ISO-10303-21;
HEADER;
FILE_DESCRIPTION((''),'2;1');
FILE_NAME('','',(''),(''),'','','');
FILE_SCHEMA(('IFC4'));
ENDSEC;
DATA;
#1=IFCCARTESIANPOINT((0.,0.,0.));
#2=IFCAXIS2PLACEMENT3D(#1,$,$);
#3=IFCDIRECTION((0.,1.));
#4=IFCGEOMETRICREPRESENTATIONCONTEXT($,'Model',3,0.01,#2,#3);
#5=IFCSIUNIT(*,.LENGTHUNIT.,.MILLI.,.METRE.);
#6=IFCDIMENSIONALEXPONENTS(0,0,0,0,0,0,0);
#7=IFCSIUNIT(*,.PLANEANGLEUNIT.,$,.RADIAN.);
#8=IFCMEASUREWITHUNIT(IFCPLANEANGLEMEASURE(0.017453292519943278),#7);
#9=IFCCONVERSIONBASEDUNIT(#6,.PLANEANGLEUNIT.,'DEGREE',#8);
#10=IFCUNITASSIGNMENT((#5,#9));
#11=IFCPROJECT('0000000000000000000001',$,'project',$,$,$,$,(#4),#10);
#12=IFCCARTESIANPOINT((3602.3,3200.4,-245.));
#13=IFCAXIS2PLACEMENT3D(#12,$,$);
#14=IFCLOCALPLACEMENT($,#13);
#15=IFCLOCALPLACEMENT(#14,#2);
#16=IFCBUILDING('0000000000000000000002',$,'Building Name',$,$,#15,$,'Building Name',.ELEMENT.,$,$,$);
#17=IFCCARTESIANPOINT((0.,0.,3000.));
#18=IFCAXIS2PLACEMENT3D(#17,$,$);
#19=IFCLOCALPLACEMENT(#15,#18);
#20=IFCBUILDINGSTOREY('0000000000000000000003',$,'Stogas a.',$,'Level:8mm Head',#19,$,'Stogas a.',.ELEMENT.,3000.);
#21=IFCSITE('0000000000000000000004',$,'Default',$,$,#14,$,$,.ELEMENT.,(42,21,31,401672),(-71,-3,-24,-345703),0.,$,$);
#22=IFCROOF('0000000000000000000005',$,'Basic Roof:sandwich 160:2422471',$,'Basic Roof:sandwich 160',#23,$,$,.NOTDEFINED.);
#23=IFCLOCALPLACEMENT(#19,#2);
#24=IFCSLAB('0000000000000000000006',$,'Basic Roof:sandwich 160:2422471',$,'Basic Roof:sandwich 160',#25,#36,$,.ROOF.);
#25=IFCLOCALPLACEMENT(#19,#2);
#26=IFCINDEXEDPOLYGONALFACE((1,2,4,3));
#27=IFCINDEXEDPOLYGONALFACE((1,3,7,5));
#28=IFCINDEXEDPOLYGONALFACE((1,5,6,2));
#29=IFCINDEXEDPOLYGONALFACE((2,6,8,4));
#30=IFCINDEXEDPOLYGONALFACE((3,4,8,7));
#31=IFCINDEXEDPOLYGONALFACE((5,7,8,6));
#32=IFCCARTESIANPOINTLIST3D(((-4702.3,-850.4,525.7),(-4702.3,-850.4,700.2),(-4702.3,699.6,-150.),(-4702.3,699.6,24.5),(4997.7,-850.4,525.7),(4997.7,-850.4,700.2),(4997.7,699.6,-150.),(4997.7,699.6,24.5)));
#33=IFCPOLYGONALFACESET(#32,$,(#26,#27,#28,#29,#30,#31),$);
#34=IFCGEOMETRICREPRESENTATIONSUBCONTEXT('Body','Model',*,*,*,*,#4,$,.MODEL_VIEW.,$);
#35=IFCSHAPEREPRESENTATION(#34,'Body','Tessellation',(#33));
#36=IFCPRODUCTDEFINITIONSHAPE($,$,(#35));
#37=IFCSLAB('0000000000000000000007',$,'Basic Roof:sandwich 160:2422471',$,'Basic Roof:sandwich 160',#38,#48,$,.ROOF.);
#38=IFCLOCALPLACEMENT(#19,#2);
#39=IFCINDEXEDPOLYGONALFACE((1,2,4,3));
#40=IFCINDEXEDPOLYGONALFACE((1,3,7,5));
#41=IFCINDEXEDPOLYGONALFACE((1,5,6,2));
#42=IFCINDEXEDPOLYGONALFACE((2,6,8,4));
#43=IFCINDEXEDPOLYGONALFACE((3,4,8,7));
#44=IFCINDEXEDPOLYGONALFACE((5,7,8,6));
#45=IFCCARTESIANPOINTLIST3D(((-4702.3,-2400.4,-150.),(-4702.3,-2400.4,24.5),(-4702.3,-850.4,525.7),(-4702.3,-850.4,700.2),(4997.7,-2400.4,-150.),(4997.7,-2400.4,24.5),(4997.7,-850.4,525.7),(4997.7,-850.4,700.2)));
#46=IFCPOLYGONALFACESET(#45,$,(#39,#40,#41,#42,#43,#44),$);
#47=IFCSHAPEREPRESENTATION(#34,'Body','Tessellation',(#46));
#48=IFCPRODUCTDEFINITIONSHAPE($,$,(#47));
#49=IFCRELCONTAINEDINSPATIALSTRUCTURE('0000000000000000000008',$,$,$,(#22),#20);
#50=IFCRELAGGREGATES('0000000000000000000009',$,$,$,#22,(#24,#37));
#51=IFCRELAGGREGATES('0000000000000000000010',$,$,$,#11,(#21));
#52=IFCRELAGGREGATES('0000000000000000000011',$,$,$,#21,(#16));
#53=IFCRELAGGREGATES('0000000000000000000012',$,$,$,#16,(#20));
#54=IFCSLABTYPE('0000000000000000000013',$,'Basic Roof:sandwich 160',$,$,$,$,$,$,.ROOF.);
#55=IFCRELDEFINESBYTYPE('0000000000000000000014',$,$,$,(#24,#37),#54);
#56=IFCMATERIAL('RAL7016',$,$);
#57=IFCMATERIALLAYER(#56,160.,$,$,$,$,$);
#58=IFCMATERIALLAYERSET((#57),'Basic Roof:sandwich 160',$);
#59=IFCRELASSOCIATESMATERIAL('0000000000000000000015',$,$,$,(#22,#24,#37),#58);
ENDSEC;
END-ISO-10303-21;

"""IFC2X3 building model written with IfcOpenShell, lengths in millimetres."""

from ifc_helpers import new_model, entity, si_unit, converted_unit, direction, frame, frame_2d, origin, place, context, subcontext, project, spatial, rectangle, extrude, material, layer, layer_set, type_object, element, aggregate, save


model = new_model("IFC2X3")

# Units and contexts
model_context = context("Model", 3, precision=0.01, world=origin(), true_north=direction((0.0, 1.0)))
body_context = subcontext(model_context, "Body", "Model", "MODEL_VIEW")
ifc_project = project(units=[si_unit("LENGTHUNIT", "METRE", prefix="MILLI"), converted_unit("PLANEANGLEUNIT", "DEGREE", entity("IfcPlaneAngleMeasure", 0.017453292519943278), si_unit("PLANEANGLEUNIT", "RADIAN"), dimensions=[0, 0, 0, 0, 0, 0, 0])], contexts=[model_context])

# Site, building, storey
site_placement = place(None, frame((3602.3, 3200.4, -245.0)))
site = spatial("IfcSite", under=ifc_project, at=site_placement, Name="Default", CompositionType="ELEMENT", RefLatitude=(42, 21, 31, 401672), RefLongitude=(-71, -3, -24, -345703), RefElevation=0.0)
building_placement = place(site_placement, origin())
building = spatial("IfcBuilding", under=site, at=building_placement, Name="Building Name", LongName="Building Name", CompositionType="ELEMENT")
storey_placement = place(building_placement, frame((0.0, 0.0, 3000.0)))
storey = spatial("IfcBuildingStorey", under=building, at=storey_placement, Name="Stogas a.", ObjectType="Level:8mm Head", LongName="Stogas a.", CompositionType="ELEMENT", Elevation=3000.0)

# Shared definitions
ifc_material_1 = material(Name="RAL7016")

# Roof, slabs
ifc_layer = layer(ifc_material_1, 160.0)
ifc_layer_set = layer_set([ifc_layer], Name="Basic Roof:sandwich 160")
roof_1_placement = place(storey_placement, frame((-4702.3, -2400.4, -150.0)))
roof_1 = element("IfcRoof", 1, at=roof_1_placement, inside=storey, material=ifc_layer_set, Name="Basic Roof:sandwich 160:2422471", ObjectType="Basic Roof:sandwich 160", ShapeType="NOTDEFINED")
slab_type = type_object("IfcSlabType", Name="Basic Roof:sandwich 160", PredefinedType="ROOF")
slab_1_placement = place(roof_1_placement, origin())
slab_1 = element("IfcSlab", 2, at=slab_1_placement, type_object=slab_type, material=ifc_layer_set, Name="Basic Roof:sandwich 160:2422471", ObjectType="Basic Roof:sandwich 160", PredefinedType="ROOF", context=body_context, shape_type="SweptSolid", body=[
    extrude(rectangle(XDim=1690.9, YDim=9700.0, at=frame_2d((0.0, 0.0), x_axis=(0.0, -1.0))), frame((4850.0, 2325.0, 337.8), z_axis=(0.0, 0.399598, 0.91669), x_axis=(1.0, 0.0, 0.0)), (0.0, -0.399598, 0.91669), 174.5),
])
slab_2_placement = place(roof_1_placement, origin())
slab_2 = element("IfcSlab", 3, at=slab_2_placement, type_object=slab_type, material=ifc_layer_set, Name="Basic Roof:sandwich 160:2422471", ObjectType="Basic Roof:sandwich 160", PredefinedType="ROOF", context=body_context, shape_type="SweptSolid", body=[
    extrude(rectangle(XDim=9700.0, YDim=1690.9, at=frame_2d((0.0, 0.0), x_axis=(-1.0, 0.0))), frame((4850.0, 775.0, 337.8), z_axis=(0.0, -0.399598, 0.91669), x_axis=(1.0, 0.0, 0.0)), (0.0, 0.399598, 0.91669), 174.5),
])
aggregate(roof_1, [slab_1, slab_2])

save(model, "model.ifc")
